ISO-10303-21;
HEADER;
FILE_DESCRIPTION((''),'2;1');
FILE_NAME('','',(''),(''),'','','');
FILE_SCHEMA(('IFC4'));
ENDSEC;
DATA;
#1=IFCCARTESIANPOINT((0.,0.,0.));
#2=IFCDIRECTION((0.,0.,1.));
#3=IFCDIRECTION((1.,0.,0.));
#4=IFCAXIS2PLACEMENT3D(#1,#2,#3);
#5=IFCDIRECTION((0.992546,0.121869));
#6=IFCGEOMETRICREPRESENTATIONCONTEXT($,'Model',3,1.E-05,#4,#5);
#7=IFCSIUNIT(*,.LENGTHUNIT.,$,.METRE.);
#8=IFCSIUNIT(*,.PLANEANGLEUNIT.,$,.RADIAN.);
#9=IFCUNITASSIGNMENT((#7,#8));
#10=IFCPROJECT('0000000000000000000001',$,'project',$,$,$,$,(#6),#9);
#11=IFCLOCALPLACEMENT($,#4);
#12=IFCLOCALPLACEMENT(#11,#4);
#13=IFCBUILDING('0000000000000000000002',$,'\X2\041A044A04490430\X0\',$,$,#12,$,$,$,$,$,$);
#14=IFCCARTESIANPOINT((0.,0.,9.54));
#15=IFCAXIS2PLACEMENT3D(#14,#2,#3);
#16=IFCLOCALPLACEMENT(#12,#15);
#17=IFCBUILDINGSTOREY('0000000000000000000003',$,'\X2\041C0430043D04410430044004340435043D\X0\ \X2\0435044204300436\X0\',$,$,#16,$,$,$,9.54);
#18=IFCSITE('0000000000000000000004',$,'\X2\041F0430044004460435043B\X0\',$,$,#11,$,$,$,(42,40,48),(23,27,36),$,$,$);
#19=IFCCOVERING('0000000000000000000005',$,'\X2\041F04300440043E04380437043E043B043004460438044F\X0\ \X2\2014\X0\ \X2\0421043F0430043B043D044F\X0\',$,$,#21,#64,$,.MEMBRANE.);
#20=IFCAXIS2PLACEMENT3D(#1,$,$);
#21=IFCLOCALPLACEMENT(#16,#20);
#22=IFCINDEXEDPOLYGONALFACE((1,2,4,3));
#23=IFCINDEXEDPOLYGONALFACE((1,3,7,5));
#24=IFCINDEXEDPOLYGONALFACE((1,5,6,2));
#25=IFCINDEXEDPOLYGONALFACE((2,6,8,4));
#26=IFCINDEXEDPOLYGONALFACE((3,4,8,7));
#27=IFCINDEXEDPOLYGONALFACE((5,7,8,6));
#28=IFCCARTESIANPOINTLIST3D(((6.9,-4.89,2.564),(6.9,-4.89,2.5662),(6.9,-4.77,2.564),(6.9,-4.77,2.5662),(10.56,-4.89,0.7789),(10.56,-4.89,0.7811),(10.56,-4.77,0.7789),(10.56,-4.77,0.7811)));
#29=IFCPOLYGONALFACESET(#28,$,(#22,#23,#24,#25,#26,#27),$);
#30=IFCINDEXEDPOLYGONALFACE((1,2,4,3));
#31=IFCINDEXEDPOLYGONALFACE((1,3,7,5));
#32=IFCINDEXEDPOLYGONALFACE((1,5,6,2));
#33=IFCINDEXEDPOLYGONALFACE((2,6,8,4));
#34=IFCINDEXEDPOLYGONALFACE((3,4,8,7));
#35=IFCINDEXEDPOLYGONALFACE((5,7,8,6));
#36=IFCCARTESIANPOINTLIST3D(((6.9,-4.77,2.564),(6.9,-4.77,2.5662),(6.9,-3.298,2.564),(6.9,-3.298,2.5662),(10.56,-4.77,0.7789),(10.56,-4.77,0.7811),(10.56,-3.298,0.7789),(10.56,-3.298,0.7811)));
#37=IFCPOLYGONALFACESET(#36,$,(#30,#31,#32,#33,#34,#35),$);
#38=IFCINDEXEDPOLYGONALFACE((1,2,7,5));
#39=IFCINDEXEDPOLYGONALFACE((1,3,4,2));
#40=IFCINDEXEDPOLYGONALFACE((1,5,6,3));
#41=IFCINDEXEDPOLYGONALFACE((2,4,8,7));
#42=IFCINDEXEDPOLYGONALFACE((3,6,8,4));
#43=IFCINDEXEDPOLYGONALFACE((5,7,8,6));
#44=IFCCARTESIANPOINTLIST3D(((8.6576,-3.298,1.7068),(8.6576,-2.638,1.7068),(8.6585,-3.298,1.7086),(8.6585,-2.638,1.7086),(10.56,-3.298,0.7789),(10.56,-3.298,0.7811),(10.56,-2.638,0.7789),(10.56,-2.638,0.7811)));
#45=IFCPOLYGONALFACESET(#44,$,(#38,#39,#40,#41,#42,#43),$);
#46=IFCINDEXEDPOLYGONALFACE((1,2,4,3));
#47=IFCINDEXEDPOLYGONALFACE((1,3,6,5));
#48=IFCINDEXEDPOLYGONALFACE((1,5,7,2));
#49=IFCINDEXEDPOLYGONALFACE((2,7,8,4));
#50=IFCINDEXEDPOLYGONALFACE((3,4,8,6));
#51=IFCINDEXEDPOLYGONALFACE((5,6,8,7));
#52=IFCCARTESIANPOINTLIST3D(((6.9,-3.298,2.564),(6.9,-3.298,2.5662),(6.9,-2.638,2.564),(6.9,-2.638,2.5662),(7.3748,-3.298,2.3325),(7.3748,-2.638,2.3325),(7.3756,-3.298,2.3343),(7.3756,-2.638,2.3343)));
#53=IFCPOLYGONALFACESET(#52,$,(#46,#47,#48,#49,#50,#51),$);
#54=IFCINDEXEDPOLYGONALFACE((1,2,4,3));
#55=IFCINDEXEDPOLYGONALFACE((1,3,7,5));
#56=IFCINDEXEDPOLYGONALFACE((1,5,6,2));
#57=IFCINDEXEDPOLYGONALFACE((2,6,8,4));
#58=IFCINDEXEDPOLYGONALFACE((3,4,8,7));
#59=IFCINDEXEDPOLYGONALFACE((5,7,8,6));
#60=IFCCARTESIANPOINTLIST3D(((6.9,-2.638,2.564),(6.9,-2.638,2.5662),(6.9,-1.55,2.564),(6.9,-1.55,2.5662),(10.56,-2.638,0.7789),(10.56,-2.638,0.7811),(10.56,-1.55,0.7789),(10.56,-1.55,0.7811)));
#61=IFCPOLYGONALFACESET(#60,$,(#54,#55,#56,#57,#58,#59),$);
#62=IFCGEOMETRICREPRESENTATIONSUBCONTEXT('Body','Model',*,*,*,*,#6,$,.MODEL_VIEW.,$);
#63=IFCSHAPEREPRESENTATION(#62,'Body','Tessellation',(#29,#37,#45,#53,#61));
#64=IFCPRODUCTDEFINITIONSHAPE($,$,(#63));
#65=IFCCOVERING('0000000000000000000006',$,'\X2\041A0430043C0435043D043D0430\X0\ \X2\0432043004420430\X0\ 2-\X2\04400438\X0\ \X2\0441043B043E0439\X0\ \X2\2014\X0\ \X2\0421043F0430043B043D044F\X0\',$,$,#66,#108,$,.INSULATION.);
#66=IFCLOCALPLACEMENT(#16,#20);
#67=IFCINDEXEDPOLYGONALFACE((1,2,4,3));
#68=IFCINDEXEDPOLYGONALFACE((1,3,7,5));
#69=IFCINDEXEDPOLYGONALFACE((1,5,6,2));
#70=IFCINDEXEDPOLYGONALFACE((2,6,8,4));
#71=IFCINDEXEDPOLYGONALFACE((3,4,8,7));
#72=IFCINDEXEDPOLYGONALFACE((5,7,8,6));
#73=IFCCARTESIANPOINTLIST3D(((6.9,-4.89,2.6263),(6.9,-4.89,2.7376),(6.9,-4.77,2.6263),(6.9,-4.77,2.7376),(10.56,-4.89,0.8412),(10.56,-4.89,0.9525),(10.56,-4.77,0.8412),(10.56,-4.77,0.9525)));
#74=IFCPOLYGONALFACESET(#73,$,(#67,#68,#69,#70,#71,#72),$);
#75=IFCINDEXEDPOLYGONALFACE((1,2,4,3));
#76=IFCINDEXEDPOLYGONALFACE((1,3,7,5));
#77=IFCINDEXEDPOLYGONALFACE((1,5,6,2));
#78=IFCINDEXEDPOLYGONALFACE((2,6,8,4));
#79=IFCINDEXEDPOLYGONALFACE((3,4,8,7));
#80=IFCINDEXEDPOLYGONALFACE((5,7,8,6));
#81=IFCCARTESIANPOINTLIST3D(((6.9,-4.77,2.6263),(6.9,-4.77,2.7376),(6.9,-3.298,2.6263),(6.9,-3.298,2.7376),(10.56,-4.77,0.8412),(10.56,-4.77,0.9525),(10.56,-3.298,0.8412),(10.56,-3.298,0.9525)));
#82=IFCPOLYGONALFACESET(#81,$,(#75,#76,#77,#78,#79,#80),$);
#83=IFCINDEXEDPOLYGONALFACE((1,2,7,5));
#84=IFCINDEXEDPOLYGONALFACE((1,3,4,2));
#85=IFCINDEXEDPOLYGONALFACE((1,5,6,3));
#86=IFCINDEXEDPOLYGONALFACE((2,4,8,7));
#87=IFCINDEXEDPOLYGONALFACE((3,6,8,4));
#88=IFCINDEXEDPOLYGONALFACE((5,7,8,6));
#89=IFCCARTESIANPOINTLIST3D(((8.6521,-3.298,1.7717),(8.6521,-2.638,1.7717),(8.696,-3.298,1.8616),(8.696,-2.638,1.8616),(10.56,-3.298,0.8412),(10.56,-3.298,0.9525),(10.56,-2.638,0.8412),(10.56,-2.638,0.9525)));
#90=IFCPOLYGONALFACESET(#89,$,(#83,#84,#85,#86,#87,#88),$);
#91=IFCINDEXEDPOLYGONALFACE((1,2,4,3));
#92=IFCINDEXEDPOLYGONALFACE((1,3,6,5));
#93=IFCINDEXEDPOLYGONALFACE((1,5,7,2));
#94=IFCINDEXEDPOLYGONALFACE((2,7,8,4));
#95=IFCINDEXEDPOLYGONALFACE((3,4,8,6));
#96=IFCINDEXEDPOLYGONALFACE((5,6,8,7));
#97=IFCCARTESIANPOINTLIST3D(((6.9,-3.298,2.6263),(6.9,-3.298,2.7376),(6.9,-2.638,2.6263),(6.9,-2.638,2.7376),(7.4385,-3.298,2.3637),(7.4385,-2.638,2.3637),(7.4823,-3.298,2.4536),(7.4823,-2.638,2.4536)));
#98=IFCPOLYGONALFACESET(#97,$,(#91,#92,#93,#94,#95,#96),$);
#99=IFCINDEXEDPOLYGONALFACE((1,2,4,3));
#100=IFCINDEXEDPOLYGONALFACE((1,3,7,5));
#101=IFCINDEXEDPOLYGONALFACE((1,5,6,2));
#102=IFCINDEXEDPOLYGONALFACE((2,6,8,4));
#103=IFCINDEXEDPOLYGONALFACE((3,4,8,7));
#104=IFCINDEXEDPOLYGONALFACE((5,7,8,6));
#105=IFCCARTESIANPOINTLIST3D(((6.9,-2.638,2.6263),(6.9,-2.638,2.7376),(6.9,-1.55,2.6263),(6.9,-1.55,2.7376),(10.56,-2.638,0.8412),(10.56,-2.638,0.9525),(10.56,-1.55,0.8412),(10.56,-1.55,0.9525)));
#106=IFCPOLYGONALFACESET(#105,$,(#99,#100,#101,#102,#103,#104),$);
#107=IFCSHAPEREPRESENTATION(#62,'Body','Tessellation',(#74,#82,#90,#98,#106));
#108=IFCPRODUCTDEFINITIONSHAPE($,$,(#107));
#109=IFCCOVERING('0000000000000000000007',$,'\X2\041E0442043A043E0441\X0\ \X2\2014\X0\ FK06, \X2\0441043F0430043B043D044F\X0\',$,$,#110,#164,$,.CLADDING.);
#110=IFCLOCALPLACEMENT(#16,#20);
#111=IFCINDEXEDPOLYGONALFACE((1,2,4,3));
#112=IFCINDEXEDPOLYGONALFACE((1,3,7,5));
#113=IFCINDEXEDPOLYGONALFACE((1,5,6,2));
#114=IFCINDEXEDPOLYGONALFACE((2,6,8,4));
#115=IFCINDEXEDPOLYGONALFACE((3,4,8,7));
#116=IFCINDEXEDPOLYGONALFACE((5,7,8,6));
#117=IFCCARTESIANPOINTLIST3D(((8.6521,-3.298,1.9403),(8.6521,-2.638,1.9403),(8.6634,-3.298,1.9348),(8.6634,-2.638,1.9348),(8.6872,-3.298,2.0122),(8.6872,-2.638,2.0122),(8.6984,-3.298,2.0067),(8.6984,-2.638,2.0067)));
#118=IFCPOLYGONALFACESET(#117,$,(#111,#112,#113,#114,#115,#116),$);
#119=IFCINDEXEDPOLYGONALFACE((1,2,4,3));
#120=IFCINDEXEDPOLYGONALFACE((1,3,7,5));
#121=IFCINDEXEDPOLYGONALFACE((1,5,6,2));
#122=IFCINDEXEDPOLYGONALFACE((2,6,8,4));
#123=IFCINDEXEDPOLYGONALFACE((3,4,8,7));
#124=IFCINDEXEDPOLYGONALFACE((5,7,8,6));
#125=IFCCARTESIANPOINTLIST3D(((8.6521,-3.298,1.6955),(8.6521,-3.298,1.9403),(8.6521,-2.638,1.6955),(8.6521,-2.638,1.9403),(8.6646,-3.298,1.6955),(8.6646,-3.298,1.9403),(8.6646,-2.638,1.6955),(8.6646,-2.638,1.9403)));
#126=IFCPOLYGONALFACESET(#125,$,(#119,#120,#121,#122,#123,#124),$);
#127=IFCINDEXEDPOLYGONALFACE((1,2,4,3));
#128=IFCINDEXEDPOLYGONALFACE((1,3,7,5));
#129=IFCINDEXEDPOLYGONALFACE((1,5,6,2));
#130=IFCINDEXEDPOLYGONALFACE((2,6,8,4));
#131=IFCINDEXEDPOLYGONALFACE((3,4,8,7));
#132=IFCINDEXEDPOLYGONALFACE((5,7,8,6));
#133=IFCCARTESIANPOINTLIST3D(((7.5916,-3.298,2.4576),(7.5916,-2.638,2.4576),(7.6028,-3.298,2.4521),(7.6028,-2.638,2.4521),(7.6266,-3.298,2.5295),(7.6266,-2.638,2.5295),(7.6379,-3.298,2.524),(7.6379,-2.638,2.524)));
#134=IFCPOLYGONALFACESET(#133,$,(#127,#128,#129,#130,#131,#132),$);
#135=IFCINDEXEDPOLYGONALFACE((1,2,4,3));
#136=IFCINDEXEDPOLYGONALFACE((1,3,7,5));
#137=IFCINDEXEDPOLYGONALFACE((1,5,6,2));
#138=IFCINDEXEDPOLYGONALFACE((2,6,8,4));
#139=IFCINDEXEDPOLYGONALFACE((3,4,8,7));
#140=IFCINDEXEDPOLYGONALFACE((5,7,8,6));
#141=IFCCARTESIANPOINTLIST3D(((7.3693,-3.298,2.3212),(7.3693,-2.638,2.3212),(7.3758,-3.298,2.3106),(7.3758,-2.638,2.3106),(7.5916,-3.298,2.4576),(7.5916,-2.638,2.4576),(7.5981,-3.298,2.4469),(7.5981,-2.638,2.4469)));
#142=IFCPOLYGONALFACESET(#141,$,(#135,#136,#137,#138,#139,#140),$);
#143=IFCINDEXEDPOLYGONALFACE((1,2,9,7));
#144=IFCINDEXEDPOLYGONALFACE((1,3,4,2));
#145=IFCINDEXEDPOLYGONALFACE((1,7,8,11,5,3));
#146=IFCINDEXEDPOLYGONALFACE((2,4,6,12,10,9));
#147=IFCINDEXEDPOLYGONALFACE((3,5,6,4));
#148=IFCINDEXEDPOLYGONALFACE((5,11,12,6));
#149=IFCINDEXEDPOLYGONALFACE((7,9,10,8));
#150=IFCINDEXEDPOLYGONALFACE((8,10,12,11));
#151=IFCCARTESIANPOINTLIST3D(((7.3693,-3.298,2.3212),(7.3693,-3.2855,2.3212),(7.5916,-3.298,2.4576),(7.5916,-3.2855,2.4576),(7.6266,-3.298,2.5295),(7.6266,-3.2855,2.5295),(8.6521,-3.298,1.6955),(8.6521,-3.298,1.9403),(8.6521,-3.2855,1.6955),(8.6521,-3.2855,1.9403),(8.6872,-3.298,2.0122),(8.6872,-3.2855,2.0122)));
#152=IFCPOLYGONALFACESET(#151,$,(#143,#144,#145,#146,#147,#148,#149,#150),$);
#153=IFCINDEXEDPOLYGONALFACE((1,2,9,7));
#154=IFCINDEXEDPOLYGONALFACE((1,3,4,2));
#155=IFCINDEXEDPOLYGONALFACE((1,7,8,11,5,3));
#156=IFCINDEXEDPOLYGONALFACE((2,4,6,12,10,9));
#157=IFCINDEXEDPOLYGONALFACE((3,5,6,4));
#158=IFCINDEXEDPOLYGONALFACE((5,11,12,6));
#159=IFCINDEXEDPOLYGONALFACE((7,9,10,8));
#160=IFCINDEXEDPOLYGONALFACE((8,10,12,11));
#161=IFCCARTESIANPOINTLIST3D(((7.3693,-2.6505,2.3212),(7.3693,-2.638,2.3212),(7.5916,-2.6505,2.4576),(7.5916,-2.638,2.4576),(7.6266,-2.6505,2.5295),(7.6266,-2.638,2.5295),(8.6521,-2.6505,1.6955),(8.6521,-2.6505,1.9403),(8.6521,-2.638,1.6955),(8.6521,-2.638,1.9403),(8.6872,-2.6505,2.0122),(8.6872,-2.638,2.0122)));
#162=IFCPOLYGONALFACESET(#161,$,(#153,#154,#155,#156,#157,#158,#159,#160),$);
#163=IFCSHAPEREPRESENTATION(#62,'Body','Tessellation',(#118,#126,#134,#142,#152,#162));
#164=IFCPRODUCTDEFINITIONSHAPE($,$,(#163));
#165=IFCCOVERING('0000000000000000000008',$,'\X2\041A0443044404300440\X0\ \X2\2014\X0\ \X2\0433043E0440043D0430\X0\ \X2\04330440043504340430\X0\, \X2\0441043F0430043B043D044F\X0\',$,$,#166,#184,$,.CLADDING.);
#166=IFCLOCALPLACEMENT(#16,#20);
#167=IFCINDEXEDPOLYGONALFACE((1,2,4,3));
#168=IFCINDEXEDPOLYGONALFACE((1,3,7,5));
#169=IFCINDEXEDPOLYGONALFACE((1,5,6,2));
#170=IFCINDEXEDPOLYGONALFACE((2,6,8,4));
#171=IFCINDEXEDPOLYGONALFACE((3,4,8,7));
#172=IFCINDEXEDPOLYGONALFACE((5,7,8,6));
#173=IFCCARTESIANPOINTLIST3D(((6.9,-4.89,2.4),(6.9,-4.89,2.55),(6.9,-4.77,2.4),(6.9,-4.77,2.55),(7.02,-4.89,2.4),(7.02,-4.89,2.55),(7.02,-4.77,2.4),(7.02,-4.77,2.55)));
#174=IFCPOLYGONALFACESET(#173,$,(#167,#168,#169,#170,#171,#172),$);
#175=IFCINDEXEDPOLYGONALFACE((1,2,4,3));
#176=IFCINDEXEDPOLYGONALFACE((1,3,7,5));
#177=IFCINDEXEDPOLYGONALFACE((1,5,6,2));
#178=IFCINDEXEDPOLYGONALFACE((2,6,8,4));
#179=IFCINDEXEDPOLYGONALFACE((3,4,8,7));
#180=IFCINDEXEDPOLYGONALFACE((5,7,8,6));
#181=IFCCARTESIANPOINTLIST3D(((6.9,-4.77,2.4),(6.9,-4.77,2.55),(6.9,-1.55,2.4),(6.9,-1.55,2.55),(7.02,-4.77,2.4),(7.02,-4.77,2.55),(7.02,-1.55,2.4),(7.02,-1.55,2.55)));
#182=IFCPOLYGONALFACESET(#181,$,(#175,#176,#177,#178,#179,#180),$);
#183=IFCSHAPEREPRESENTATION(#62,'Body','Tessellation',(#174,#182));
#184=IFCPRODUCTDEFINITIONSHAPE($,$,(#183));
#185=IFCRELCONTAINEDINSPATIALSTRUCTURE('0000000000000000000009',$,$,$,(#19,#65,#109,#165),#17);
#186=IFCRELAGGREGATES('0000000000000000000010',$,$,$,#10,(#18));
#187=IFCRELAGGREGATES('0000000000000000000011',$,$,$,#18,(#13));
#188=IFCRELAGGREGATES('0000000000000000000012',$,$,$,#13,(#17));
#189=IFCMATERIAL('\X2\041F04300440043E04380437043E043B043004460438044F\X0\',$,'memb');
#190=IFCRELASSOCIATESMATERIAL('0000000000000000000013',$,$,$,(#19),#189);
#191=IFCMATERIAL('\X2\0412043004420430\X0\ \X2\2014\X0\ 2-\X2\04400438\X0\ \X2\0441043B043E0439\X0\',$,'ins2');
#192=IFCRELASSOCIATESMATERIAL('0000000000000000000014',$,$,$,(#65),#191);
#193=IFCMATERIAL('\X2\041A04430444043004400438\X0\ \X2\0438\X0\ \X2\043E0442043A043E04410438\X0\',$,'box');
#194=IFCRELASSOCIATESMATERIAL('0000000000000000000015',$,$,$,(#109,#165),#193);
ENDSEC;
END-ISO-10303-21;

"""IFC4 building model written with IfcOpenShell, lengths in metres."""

from ifc_helpers import new_model, si_unit, direction, frame, origin_with_axes, place, context, subcontext, project, spatial, polyline, outline, extrude, material, element, save


model = new_model("IFC4")

# Units and contexts
model_context = context("Model", 3, precision=1e-05, world=origin_with_axes(), true_north=direction((0.992546, 0.121869)))
body_context = subcontext(model_context, "Body", "Model", "MODEL_VIEW")
ifc_project = project(units=[si_unit("LENGTHUNIT", "METRE"), si_unit("PLANEANGLEUNIT", "RADIAN")], contexts=[model_context])

# Site, building, storey
site_placement = place(None, origin_with_axes())
site = spatial("IfcSite", under=ifc_project, at=site_placement, Name="Парцел", RefLatitude=(42, 40, 48), RefLongitude=(23, 27, 36))
building_placement = place(site_placement, origin_with_axes())
building = spatial("IfcBuilding", under=site, at=building_placement, Name="Къща")
storey_placement = place(building_placement, frame((0.0, 0.0, 9.54), z_axis=(0.0, 0.0, 1.0), x_axis=(1.0, 0.0, 0.0)))
storey = spatial("IfcBuildingStorey", under=building, at=storey_placement, Name="Мансарден етаж", Elevation=9.54)

# Coverings
ifc_material_1 = material(Name="Пароизолация", Category="memb")
covering_1_placement = place(storey_placement, origin_with_axes())
element("IfcCovering", 1, at=covering_1_placement, inside=storey, material=ifc_material_1, Name="Пароизолация — Спалня", PredefinedType="MEMBRANE", context=body_context, shape_type="SweptSolid", body=[
    extrude(outline(polyline([(10.56, -0.7789), (6.9, -2.564), (6.9, -2.5662), (10.56, -0.7811), (10.56, -0.7789)])), frame((0.0, -4.89, 0.0), z_axis=(0.0, 1.0, 0.0), x_axis=(1.0, 0.0, 0.0)), (0.0, 0.0, 1.0), 0.12),
    extrude(outline(polyline([(10.56, -0.7789), (6.9, -2.564), (6.9, -2.5662), (10.56, -0.7811), (10.56, -0.7789)])), frame((0.0, -4.77, 0.0), z_axis=(0.0, 1.0, 0.0), x_axis=(1.0, 0.0, 0.0)), (0.0, 0.0, 1.0), 1.472),
    extrude(outline(polyline([(10.56, -0.7789), (8.6576, -1.7068), (8.6585, -1.7086), (10.56, -0.7811), (10.56, -0.7789)])), frame((0.0, -3.298, 0.0), z_axis=(0.0, 1.0, 0.0), x_axis=(1.0, 0.0, 0.0)), (0.0, 0.0, 1.0), 0.66),
    extrude(outline(polyline([(7.3748, -2.3325), (6.9, -2.564), (6.9, -2.5662), (7.3756, -2.3342), (7.3748, -2.3325)])), frame((0.0, -3.298, 0.0), z_axis=(0.0, 1.0, 0.0), x_axis=(1.0, 0.0, 0.0)), (0.0, 0.0, 1.0), 0.66),
    extrude(outline(polyline([(10.56, -0.7789), (6.9, -2.564), (6.9, -2.5662), (10.56, -0.7811), (10.56, -0.7789)])), frame((0.0, -2.638, 0.0), z_axis=(0.0, 1.0, 0.0), x_axis=(1.0, 0.0, 0.0)), (0.0, 0.0, 1.0), 1.088),
])
ifc_material_2 = material(Name="Вата — 2-ри слой", Category="ins2")
covering_2_placement = place(storey_placement, origin_with_axes())
element("IfcCovering", 2, at=covering_2_placement, inside=storey, material=ifc_material_2, Name="Каменна вата 2-ри слой — Спалня", PredefinedType="INSULATION", context=body_context, shape_type="SweptSolid", body=[
    extrude(outline(polyline([(10.56, -0.8412), (6.9, -2.6263), (6.9, -2.7376), (10.56, -0.9525), (10.56, -0.8412)])), frame((0.0, -4.89, 0.0), z_axis=(0.0, 1.0, 0.0), x_axis=(1.0, 0.0, 0.0)), (0.0, 0.0, 1.0), 0.12),
    extrude(outline(polyline([(10.56, -0.8412), (6.9, -2.6263), (6.9, -2.7376), (10.56, -0.9525), (10.56, -0.8412)])), frame((0.0, -4.77, 0.0), z_axis=(0.0, 1.0, 0.0), x_axis=(1.0, 0.0, 0.0)), (0.0, 0.0, 1.0), 1.472),
    extrude(outline(polyline([(10.56, -0.8412), (8.6521, -1.7717), (8.696, -1.8616), (10.56, -0.9525), (10.56, -0.8412)])), frame((0.0, -3.298, 0.0), z_axis=(0.0, 1.0, 0.0), x_axis=(1.0, 0.0, 0.0)), (0.0, 0.0, 1.0), 0.66),
    extrude(outline(polyline([(7.4385, -2.3637), (6.9, -2.6263), (6.9, -2.7376), (7.4823, -2.4536), (7.4385, -2.3637)])), frame((0.0, -3.298, 0.0), z_axis=(0.0, 1.0, 0.0), x_axis=(1.0, 0.0, 0.0)), (0.0, 0.0, 1.0), 0.66),
    extrude(outline(polyline([(10.56, -0.8412), (6.9, -2.6263), (6.9, -2.7376), (10.56, -0.9525), (10.56, -0.8412)])), frame((0.0, -2.638, 0.0), z_axis=(0.0, 1.0, 0.0), x_axis=(1.0, 0.0, 0.0)), (0.0, 0.0, 1.0), 1.088),
])
ifc_material_3 = material(Name="Куфари и откоси", Category="box")
covering_3_placement = place(storey_placement, origin_with_axes())
element("IfcCovering", 3, at=covering_3_placement, inside=storey, material=ifc_material_3, Name="Откос — FK06, спалня", PredefinedType="CLADDING", context=body_context, shape_type="SweptSolid", body=[
    extrude(outline(polyline([(8.6872, -2.0122), (8.6521, -1.9403), (8.6634, -1.9348), (8.6984, -2.0067), (8.6872, -2.0122)])), frame((0.0, -3.298, 0.0), z_axis=(0.0, 1.0, 0.0), x_axis=(1.0, 0.0, 0.0)), (0.0, 0.0, 1.0), 0.66),
    extrude(outline(polyline([(8.6521, -1.9403), (8.6521, -1.6955), (8.6646, -1.6955), (8.6646, -1.9403), (8.6521, -1.9403)])), frame((0.0, -3.298, 0.0), z_axis=(0.0, 1.0, 0.0), x_axis=(1.0, 0.0, 0.0)), (0.0, 0.0, 1.0), 0.66),
    extrude(outline(polyline([(7.6266, -2.5295), (7.5916, -2.4576), (7.6028, -2.4521), (7.6379, -2.524), (7.6266, -2.5295)])), frame((0.0, -3.298, 0.0), z_axis=(0.0, 1.0, 0.0), x_axis=(1.0, 0.0, 0.0)), (0.0, 0.0, 1.0), 0.66),
    extrude(outline(polyline([(7.5916, -2.4576), (7.3693, -2.3212), (7.3758, -2.3106), (7.5981, -2.4469), (7.5916, -2.4576)])), frame((0.0, -3.298, 0.0), z_axis=(0.0, 1.0, 0.0), x_axis=(1.0, 0.0, 0.0)), (0.0, 0.0, 1.0), 0.66),
    extrude(outline(polyline([(8.6521, -1.6955), (8.6521, -1.9403), (8.6872, -2.0122), (7.6266, -2.5295), (7.5916, -2.4576), (7.3693, -2.3212), (8.6521, -1.6955)])), frame((0.0, -3.298, 0.0), z_axis=(0.0, 1.0, 0.0), x_axis=(1.0, 0.0, 0.0)), (0.0, 0.0, 1.0), 0.0125),
    extrude(outline(polyline([(8.6521, -1.6955), (8.6521, -1.9403), (8.6872, -2.0122), (7.6266, -2.5295), (7.5916, -2.4576), (7.3693, -2.3212), (8.6521, -1.6955)])), frame((0.0, -2.6505, 0.0), z_axis=(0.0, 1.0, 0.0), x_axis=(1.0, 0.0, 0.0)), (0.0, 0.0, 1.0), 0.0125),
])
covering_4_placement = place(storey_placement, origin_with_axes())
element("IfcCovering", 4, at=covering_4_placement, inside=storey, material=ifc_material_3, Name="Куфар — горна греда, спалня", PredefinedType="CLADDING", context=body_context, shape_type="SweptSolid", body=[
    extrude(outline(polyline([(6.9, -2.4), (7.02, -2.4), (7.02, -2.55), (6.9, -2.55), (6.9, -2.4)])), frame((0.0, -4.89, 0.0), z_axis=(0.0, 1.0, 0.0), x_axis=(1.0, 0.0, 0.0)), (0.0, 0.0, 1.0), 0.12),
    extrude(outline(polyline([(6.9, -2.4), (7.02, -2.4), (7.02, -2.55), (6.9, -2.55), (6.9, -2.4)])), frame((0.0, -4.77, 0.0), z_axis=(0.0, 1.0, 0.0), x_axis=(1.0, 0.0, 0.0)), (0.0, 0.0, 1.0), 3.22),
])

save(model, "model.ifc")
